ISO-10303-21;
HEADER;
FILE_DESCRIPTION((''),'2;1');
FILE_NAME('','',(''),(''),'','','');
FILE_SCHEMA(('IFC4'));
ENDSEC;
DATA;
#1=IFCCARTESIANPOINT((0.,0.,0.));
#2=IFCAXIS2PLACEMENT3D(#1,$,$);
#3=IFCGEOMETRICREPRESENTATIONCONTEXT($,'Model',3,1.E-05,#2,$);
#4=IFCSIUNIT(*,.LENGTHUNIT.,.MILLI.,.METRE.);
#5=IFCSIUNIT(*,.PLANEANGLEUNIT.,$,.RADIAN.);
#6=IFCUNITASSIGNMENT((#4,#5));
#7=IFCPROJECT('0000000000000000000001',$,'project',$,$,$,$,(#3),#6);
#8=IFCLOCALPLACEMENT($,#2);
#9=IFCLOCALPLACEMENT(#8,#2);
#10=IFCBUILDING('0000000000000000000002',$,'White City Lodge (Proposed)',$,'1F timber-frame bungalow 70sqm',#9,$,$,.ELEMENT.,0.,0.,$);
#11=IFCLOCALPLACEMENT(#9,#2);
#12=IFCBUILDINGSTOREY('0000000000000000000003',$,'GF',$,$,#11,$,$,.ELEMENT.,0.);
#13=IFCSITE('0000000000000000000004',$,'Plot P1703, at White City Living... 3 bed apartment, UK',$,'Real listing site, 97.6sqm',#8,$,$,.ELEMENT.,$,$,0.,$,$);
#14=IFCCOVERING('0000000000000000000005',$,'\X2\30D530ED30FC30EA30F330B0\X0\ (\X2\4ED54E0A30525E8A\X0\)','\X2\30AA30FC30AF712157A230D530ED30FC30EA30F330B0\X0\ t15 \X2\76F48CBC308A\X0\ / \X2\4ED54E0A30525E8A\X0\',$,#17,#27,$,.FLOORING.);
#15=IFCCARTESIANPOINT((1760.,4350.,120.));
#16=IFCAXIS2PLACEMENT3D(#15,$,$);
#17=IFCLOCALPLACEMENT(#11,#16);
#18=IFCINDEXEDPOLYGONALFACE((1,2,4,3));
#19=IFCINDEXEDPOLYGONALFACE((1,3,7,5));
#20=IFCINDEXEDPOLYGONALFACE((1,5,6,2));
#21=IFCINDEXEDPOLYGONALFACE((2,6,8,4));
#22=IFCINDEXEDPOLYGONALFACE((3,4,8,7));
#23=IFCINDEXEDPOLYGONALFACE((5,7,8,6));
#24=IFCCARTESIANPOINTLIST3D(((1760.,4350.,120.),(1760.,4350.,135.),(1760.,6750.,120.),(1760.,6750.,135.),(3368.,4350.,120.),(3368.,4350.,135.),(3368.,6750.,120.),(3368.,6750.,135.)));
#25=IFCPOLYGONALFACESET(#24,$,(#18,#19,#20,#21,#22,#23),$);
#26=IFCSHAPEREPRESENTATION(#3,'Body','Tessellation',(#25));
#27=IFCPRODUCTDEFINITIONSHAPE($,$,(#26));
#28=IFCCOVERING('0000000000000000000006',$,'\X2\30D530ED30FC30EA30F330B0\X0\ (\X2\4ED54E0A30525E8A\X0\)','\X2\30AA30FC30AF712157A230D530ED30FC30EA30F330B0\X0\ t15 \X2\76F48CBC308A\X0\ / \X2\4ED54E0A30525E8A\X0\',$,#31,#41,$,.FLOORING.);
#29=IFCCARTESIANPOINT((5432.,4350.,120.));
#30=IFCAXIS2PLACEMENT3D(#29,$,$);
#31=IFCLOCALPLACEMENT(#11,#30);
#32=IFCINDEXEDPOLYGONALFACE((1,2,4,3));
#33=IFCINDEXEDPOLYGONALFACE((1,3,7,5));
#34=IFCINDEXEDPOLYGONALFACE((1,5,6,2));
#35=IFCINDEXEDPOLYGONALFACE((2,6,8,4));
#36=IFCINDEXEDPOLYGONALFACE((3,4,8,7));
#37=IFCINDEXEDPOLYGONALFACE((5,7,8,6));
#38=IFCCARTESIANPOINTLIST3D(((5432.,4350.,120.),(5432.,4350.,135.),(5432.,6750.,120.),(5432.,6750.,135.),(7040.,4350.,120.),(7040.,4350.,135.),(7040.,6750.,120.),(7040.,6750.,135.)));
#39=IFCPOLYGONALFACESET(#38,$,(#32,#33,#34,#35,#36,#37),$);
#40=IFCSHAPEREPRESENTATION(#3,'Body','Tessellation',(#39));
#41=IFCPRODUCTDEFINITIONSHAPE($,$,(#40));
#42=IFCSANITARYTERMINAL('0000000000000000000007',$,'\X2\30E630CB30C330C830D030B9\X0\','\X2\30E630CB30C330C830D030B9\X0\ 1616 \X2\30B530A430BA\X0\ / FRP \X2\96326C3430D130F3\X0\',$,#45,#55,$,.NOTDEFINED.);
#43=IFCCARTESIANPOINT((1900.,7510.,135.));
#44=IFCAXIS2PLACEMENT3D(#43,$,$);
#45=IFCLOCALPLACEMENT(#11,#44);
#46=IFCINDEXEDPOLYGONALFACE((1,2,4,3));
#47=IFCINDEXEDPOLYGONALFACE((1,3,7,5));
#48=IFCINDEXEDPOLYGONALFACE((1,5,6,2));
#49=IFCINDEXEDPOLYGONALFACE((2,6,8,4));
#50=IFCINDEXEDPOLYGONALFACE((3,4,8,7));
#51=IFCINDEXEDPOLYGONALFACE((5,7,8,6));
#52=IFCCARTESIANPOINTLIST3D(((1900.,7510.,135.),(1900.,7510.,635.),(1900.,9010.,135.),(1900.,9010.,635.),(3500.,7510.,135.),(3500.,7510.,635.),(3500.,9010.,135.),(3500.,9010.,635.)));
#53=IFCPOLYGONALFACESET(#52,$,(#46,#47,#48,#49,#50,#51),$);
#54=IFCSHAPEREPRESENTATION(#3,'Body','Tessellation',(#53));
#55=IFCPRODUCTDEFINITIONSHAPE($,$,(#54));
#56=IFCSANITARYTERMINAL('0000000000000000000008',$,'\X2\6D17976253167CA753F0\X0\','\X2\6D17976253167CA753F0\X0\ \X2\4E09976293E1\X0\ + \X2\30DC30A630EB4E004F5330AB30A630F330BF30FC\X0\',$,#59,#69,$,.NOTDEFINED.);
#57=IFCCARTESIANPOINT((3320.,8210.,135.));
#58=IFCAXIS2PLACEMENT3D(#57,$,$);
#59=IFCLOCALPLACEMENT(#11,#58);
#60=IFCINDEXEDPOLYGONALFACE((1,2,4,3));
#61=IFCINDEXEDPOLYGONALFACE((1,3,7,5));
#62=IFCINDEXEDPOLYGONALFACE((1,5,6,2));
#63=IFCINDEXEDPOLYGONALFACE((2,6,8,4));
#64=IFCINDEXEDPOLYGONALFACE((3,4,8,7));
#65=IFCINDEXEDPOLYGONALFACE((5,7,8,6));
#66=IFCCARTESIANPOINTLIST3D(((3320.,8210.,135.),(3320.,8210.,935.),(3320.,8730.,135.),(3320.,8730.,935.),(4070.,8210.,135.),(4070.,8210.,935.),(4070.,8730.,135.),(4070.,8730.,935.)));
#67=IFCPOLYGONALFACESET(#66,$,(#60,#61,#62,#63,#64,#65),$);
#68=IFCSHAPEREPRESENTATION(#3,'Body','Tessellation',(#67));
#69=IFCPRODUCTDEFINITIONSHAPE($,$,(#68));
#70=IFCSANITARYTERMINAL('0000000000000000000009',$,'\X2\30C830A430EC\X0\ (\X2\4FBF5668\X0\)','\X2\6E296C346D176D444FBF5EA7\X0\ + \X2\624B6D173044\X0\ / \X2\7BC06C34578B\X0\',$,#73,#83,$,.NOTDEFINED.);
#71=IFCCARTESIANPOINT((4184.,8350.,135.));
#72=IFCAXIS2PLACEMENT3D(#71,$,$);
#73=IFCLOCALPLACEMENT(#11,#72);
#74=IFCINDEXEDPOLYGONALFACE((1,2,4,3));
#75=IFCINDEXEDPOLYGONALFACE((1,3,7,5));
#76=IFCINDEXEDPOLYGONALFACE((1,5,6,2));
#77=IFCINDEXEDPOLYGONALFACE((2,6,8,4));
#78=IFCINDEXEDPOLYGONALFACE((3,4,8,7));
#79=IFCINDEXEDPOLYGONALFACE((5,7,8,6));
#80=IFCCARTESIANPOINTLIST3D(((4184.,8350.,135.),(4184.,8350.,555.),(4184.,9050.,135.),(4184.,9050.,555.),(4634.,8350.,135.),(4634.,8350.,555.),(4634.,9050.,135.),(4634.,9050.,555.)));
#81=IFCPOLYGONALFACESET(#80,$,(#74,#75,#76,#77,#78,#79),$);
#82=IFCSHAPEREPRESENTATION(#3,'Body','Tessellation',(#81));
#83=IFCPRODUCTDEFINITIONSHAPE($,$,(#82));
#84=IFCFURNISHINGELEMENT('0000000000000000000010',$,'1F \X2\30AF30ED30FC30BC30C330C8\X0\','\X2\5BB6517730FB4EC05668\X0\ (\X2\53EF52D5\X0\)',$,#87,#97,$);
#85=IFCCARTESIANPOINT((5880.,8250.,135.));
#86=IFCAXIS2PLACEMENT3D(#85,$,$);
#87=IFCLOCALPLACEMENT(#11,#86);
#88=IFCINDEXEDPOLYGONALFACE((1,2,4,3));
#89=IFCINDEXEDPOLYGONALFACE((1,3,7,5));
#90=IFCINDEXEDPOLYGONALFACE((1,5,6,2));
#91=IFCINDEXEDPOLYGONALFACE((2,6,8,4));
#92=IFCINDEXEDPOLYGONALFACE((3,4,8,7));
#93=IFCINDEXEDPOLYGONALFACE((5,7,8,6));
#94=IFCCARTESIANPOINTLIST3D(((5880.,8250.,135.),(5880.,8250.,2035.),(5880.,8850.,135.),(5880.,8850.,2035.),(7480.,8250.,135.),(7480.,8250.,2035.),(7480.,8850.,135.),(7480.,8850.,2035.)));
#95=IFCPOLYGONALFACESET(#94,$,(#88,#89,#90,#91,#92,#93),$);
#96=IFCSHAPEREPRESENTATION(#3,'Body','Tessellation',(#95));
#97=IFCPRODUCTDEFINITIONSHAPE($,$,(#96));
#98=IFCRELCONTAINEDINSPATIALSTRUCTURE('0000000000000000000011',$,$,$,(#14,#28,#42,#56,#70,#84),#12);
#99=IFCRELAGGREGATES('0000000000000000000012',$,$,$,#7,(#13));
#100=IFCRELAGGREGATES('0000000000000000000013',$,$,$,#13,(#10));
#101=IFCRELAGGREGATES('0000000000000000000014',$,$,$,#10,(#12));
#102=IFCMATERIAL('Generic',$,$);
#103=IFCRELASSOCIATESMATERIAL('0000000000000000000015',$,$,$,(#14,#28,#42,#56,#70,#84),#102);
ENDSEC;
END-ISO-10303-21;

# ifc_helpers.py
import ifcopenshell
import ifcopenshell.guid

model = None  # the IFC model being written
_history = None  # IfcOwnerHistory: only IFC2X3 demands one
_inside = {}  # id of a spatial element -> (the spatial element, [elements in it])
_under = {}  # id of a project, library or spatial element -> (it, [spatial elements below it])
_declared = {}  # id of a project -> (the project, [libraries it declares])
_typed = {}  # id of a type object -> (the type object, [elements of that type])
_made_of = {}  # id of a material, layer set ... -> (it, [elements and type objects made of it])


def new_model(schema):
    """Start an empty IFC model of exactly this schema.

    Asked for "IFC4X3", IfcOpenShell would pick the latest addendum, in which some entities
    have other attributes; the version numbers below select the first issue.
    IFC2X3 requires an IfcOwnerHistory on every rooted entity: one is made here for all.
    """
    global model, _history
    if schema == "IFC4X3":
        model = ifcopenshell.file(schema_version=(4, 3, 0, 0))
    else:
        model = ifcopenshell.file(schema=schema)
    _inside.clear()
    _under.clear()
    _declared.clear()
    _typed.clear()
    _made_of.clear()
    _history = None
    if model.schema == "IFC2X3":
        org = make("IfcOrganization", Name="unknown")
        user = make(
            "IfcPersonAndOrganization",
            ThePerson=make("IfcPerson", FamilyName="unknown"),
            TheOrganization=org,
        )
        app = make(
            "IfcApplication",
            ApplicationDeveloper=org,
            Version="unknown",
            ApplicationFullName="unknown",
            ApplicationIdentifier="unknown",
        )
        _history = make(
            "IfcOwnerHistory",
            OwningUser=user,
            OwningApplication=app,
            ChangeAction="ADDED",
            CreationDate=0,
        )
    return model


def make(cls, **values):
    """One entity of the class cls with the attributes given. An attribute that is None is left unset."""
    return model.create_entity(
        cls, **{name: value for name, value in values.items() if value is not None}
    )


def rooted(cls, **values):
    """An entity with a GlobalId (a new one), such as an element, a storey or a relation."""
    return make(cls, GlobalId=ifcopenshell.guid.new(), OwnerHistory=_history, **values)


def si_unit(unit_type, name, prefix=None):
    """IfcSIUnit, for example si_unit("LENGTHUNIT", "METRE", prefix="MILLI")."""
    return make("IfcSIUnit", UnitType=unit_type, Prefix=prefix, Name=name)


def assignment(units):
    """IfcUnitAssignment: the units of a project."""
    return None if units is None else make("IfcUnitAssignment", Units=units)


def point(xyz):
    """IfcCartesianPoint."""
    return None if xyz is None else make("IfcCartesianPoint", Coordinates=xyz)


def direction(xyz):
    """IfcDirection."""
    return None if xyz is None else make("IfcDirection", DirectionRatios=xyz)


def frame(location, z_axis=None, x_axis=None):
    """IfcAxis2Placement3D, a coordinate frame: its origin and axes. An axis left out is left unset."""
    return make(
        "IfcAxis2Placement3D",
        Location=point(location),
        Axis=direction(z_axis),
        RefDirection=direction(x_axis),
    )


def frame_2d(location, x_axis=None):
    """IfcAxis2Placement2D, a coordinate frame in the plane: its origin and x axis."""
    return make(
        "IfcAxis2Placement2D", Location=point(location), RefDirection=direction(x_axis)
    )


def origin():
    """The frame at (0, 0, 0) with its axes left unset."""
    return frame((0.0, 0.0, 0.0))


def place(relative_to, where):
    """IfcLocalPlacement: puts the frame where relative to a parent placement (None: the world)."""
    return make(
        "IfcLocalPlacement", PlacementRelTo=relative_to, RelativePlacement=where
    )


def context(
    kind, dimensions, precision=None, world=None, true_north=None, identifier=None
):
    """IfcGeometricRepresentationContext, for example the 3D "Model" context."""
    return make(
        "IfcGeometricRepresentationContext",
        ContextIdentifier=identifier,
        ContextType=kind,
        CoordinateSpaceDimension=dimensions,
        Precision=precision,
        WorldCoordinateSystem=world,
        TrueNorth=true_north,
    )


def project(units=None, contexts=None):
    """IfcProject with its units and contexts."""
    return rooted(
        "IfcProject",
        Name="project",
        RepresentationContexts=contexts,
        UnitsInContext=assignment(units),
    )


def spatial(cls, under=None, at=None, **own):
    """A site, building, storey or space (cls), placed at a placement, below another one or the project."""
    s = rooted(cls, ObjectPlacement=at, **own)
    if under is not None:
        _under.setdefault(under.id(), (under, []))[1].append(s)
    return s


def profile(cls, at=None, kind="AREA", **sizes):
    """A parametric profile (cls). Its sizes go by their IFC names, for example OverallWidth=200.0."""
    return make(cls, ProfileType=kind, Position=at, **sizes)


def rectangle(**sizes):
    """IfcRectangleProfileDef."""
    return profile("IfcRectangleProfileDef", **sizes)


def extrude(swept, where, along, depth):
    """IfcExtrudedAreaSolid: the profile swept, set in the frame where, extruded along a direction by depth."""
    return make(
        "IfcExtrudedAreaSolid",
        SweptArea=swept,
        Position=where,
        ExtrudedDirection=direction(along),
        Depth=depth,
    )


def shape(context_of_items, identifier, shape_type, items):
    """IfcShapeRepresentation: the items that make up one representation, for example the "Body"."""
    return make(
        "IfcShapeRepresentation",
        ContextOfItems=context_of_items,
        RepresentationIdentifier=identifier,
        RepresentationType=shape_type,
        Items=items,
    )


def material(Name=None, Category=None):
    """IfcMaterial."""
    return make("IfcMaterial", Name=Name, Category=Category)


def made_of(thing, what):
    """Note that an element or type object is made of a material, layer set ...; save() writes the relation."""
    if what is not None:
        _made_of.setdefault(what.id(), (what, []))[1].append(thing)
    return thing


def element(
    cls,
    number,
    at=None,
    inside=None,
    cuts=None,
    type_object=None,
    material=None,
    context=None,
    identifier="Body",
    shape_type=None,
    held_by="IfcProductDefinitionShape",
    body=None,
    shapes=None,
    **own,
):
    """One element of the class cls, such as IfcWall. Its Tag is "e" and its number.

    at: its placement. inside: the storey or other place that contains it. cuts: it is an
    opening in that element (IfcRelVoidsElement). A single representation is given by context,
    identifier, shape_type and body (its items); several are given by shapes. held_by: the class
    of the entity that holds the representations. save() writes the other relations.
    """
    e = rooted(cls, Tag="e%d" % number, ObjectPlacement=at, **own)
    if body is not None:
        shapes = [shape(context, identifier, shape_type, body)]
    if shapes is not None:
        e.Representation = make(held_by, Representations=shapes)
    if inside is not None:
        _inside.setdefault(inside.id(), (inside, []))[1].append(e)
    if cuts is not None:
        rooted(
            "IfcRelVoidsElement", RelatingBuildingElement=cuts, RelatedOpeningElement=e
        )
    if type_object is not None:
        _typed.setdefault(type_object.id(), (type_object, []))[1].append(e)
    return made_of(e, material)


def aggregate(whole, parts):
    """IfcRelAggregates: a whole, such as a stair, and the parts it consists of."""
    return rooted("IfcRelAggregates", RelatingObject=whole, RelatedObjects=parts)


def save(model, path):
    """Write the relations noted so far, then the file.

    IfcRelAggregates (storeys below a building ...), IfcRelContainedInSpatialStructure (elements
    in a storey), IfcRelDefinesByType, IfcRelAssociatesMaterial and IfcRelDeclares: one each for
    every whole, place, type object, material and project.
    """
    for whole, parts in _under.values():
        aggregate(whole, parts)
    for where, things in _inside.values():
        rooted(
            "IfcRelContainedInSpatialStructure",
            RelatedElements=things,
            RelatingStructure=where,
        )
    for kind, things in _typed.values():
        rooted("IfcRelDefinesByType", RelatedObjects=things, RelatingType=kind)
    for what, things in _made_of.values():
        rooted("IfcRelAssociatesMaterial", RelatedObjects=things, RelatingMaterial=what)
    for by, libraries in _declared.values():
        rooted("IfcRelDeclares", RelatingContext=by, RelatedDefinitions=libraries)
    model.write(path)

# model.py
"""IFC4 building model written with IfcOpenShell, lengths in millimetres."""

from ifc_helpers import new_model, si_unit, frame, frame_2d, origin, place, context, project, spatial, rectangle, extrude, material, element, save


model = new_model("IFC4")

# Units and contexts
model_context = context("Model", 3, precision=1e-05, world=origin())
ifc_project = project(units=[si_unit("LENGTHUNIT", "METRE", prefix="MILLI"), si_unit("PLANEANGLEUNIT", "RADIAN")], contexts=[model_context])

# Site, building, storey
site_placement = place(None, origin())
site = spatial("IfcSite", under=ifc_project, at=site_placement, Name="Plot P1703, at White City Living... 3 bed apartment, UK", ObjectType="Real listing site, 97.6sqm", CompositionType="ELEMENT", RefElevation=0.0)
building_placement = place(site_placement, origin())
building = spatial("IfcBuilding", under=site, at=building_placement, Name="White City Lodge (Proposed)", ObjectType="1F timber-frame bungalow 70sqm", CompositionType="ELEMENT", ElevationOfRefHeight=0.0, ElevationOfTerrain=0.0)
storey_placement = place(building_placement, origin())
storey = spatial("IfcBuildingStorey", under=building, at=storey_placement, Name="GF", CompositionType="ELEMENT", Elevation=0.0)

# Coverings
ifc_material_1 = material(Name="Generic")
covering_1_placement = place(storey_placement, frame((1760.0, 4350.0, 120.0)))
element("IfcCovering", 1, at=covering_1_placement, inside=storey, material=ifc_material_1, Name="フローリング (仕上げ床)", Description="オーク無垢フローリング t15 直貼り / 仕上げ床", PredefinedType="FLOORING", context=model_context, shape_type="SweptSolid", body=[
    extrude(rectangle(XDim=1608.0, YDim=2400.0, at=frame_2d((804.0, 1200.0))), frame((1760.0, 4350.0, 120.0)), (0.0, 0.0, 1.0), 15.0),
])
covering_2_placement = place(storey_placement, frame((5432.0, 4350.0, 120.0)))
element("IfcCovering", 2, at=covering_2_placement, inside=storey, material=ifc_material_1, Name="フローリング (仕上げ床)", Description="オーク無垢フローリング t15 直貼り / 仕上げ床", PredefinedType="FLOORING", context=model_context, shape_type="SweptSolid", body=[
    extrude(rectangle(XDim=1608.0, YDim=2400.0, at=frame_2d((804.0, 1200.0))), frame((5432.0, 4350.0, 120.0)), (0.0, 0.0, 1.0), 15.0),
])

# Sanitary terminals
sanitary_terminal_1_placement = place(storey_placement, frame((1900.0, 7510.0, 135.0)))
element("IfcSanitaryTerminal", 3, at=sanitary_terminal_1_placement, inside=storey, material=ifc_material_1, Name="ユニットバス", Description="ユニットバス 1616 サイズ / FRP 防水パン", PredefinedType="NOTDEFINED", context=model_context, shape_type="SweptSolid", body=[
    extrude(rectangle(XDim=1600.0, YDim=1500.0, at=frame_2d((800.0, 750.0))), frame((1900.0, 7510.0, 135.0)), (0.0, 0.0, 1.0), 500.0),
])
sanitary_terminal_2_placement = place(storey_placement, frame((3320.0, 8210.0, 135.0)))
element("IfcSanitaryTerminal", 4, at=sanitary_terminal_2_placement, inside=storey, material=ifc_material_1, Name="洗面化粧台", Description="洗面化粧台 三面鏡 + ボウル一体カウンター", PredefinedType="NOTDEFINED", context=model_context, shape_type="SweptSolid", body=[
    extrude(rectangle(XDim=750.0, YDim=520.0, at=frame_2d((375.0, 260.0))), frame((3320.0, 8210.0, 135.0)), (0.0, 0.0, 1.0), 800.0),
])
sanitary_terminal_3_placement = place(storey_placement, frame((4184.0, 8350.0, 135.0)))
element("IfcSanitaryTerminal", 5, at=sanitary_terminal_3_placement, inside=storey, material=ifc_material_1, Name="トイレ (便器)", Description="温水洗浄便座 + 手洗い / 節水型", PredefinedType="NOTDEFINED", context=model_context, shape_type="SweptSolid", body=[
    extrude(rectangle(XDim=450.0, YDim=700.0, at=frame_2d((225.0, 350.0))), frame((4184.0, 8350.0, 135.0)), (0.0, 0.0, 1.0), 420.0),
])

# Furnishing element
furnishing_placement = place(storey_placement, frame((5880.0, 8250.0, 135.0)))
element("IfcFurnishingElement", 6, at=furnishing_placement, inside=storey, material=ifc_material_1, Name="1F クローゼット", Description="家具・什器 (可動)", context=model_context, shape_type="SweptSolid", body=[
    extrude(rectangle(XDim=1600.0, YDim=600.0, at=frame_2d((800.0, 300.0))), frame((5880.0, 8250.0, 135.0)), (0.0, 0.0, 1.0), 1900.0),
])

save(model, "model.ifc")
